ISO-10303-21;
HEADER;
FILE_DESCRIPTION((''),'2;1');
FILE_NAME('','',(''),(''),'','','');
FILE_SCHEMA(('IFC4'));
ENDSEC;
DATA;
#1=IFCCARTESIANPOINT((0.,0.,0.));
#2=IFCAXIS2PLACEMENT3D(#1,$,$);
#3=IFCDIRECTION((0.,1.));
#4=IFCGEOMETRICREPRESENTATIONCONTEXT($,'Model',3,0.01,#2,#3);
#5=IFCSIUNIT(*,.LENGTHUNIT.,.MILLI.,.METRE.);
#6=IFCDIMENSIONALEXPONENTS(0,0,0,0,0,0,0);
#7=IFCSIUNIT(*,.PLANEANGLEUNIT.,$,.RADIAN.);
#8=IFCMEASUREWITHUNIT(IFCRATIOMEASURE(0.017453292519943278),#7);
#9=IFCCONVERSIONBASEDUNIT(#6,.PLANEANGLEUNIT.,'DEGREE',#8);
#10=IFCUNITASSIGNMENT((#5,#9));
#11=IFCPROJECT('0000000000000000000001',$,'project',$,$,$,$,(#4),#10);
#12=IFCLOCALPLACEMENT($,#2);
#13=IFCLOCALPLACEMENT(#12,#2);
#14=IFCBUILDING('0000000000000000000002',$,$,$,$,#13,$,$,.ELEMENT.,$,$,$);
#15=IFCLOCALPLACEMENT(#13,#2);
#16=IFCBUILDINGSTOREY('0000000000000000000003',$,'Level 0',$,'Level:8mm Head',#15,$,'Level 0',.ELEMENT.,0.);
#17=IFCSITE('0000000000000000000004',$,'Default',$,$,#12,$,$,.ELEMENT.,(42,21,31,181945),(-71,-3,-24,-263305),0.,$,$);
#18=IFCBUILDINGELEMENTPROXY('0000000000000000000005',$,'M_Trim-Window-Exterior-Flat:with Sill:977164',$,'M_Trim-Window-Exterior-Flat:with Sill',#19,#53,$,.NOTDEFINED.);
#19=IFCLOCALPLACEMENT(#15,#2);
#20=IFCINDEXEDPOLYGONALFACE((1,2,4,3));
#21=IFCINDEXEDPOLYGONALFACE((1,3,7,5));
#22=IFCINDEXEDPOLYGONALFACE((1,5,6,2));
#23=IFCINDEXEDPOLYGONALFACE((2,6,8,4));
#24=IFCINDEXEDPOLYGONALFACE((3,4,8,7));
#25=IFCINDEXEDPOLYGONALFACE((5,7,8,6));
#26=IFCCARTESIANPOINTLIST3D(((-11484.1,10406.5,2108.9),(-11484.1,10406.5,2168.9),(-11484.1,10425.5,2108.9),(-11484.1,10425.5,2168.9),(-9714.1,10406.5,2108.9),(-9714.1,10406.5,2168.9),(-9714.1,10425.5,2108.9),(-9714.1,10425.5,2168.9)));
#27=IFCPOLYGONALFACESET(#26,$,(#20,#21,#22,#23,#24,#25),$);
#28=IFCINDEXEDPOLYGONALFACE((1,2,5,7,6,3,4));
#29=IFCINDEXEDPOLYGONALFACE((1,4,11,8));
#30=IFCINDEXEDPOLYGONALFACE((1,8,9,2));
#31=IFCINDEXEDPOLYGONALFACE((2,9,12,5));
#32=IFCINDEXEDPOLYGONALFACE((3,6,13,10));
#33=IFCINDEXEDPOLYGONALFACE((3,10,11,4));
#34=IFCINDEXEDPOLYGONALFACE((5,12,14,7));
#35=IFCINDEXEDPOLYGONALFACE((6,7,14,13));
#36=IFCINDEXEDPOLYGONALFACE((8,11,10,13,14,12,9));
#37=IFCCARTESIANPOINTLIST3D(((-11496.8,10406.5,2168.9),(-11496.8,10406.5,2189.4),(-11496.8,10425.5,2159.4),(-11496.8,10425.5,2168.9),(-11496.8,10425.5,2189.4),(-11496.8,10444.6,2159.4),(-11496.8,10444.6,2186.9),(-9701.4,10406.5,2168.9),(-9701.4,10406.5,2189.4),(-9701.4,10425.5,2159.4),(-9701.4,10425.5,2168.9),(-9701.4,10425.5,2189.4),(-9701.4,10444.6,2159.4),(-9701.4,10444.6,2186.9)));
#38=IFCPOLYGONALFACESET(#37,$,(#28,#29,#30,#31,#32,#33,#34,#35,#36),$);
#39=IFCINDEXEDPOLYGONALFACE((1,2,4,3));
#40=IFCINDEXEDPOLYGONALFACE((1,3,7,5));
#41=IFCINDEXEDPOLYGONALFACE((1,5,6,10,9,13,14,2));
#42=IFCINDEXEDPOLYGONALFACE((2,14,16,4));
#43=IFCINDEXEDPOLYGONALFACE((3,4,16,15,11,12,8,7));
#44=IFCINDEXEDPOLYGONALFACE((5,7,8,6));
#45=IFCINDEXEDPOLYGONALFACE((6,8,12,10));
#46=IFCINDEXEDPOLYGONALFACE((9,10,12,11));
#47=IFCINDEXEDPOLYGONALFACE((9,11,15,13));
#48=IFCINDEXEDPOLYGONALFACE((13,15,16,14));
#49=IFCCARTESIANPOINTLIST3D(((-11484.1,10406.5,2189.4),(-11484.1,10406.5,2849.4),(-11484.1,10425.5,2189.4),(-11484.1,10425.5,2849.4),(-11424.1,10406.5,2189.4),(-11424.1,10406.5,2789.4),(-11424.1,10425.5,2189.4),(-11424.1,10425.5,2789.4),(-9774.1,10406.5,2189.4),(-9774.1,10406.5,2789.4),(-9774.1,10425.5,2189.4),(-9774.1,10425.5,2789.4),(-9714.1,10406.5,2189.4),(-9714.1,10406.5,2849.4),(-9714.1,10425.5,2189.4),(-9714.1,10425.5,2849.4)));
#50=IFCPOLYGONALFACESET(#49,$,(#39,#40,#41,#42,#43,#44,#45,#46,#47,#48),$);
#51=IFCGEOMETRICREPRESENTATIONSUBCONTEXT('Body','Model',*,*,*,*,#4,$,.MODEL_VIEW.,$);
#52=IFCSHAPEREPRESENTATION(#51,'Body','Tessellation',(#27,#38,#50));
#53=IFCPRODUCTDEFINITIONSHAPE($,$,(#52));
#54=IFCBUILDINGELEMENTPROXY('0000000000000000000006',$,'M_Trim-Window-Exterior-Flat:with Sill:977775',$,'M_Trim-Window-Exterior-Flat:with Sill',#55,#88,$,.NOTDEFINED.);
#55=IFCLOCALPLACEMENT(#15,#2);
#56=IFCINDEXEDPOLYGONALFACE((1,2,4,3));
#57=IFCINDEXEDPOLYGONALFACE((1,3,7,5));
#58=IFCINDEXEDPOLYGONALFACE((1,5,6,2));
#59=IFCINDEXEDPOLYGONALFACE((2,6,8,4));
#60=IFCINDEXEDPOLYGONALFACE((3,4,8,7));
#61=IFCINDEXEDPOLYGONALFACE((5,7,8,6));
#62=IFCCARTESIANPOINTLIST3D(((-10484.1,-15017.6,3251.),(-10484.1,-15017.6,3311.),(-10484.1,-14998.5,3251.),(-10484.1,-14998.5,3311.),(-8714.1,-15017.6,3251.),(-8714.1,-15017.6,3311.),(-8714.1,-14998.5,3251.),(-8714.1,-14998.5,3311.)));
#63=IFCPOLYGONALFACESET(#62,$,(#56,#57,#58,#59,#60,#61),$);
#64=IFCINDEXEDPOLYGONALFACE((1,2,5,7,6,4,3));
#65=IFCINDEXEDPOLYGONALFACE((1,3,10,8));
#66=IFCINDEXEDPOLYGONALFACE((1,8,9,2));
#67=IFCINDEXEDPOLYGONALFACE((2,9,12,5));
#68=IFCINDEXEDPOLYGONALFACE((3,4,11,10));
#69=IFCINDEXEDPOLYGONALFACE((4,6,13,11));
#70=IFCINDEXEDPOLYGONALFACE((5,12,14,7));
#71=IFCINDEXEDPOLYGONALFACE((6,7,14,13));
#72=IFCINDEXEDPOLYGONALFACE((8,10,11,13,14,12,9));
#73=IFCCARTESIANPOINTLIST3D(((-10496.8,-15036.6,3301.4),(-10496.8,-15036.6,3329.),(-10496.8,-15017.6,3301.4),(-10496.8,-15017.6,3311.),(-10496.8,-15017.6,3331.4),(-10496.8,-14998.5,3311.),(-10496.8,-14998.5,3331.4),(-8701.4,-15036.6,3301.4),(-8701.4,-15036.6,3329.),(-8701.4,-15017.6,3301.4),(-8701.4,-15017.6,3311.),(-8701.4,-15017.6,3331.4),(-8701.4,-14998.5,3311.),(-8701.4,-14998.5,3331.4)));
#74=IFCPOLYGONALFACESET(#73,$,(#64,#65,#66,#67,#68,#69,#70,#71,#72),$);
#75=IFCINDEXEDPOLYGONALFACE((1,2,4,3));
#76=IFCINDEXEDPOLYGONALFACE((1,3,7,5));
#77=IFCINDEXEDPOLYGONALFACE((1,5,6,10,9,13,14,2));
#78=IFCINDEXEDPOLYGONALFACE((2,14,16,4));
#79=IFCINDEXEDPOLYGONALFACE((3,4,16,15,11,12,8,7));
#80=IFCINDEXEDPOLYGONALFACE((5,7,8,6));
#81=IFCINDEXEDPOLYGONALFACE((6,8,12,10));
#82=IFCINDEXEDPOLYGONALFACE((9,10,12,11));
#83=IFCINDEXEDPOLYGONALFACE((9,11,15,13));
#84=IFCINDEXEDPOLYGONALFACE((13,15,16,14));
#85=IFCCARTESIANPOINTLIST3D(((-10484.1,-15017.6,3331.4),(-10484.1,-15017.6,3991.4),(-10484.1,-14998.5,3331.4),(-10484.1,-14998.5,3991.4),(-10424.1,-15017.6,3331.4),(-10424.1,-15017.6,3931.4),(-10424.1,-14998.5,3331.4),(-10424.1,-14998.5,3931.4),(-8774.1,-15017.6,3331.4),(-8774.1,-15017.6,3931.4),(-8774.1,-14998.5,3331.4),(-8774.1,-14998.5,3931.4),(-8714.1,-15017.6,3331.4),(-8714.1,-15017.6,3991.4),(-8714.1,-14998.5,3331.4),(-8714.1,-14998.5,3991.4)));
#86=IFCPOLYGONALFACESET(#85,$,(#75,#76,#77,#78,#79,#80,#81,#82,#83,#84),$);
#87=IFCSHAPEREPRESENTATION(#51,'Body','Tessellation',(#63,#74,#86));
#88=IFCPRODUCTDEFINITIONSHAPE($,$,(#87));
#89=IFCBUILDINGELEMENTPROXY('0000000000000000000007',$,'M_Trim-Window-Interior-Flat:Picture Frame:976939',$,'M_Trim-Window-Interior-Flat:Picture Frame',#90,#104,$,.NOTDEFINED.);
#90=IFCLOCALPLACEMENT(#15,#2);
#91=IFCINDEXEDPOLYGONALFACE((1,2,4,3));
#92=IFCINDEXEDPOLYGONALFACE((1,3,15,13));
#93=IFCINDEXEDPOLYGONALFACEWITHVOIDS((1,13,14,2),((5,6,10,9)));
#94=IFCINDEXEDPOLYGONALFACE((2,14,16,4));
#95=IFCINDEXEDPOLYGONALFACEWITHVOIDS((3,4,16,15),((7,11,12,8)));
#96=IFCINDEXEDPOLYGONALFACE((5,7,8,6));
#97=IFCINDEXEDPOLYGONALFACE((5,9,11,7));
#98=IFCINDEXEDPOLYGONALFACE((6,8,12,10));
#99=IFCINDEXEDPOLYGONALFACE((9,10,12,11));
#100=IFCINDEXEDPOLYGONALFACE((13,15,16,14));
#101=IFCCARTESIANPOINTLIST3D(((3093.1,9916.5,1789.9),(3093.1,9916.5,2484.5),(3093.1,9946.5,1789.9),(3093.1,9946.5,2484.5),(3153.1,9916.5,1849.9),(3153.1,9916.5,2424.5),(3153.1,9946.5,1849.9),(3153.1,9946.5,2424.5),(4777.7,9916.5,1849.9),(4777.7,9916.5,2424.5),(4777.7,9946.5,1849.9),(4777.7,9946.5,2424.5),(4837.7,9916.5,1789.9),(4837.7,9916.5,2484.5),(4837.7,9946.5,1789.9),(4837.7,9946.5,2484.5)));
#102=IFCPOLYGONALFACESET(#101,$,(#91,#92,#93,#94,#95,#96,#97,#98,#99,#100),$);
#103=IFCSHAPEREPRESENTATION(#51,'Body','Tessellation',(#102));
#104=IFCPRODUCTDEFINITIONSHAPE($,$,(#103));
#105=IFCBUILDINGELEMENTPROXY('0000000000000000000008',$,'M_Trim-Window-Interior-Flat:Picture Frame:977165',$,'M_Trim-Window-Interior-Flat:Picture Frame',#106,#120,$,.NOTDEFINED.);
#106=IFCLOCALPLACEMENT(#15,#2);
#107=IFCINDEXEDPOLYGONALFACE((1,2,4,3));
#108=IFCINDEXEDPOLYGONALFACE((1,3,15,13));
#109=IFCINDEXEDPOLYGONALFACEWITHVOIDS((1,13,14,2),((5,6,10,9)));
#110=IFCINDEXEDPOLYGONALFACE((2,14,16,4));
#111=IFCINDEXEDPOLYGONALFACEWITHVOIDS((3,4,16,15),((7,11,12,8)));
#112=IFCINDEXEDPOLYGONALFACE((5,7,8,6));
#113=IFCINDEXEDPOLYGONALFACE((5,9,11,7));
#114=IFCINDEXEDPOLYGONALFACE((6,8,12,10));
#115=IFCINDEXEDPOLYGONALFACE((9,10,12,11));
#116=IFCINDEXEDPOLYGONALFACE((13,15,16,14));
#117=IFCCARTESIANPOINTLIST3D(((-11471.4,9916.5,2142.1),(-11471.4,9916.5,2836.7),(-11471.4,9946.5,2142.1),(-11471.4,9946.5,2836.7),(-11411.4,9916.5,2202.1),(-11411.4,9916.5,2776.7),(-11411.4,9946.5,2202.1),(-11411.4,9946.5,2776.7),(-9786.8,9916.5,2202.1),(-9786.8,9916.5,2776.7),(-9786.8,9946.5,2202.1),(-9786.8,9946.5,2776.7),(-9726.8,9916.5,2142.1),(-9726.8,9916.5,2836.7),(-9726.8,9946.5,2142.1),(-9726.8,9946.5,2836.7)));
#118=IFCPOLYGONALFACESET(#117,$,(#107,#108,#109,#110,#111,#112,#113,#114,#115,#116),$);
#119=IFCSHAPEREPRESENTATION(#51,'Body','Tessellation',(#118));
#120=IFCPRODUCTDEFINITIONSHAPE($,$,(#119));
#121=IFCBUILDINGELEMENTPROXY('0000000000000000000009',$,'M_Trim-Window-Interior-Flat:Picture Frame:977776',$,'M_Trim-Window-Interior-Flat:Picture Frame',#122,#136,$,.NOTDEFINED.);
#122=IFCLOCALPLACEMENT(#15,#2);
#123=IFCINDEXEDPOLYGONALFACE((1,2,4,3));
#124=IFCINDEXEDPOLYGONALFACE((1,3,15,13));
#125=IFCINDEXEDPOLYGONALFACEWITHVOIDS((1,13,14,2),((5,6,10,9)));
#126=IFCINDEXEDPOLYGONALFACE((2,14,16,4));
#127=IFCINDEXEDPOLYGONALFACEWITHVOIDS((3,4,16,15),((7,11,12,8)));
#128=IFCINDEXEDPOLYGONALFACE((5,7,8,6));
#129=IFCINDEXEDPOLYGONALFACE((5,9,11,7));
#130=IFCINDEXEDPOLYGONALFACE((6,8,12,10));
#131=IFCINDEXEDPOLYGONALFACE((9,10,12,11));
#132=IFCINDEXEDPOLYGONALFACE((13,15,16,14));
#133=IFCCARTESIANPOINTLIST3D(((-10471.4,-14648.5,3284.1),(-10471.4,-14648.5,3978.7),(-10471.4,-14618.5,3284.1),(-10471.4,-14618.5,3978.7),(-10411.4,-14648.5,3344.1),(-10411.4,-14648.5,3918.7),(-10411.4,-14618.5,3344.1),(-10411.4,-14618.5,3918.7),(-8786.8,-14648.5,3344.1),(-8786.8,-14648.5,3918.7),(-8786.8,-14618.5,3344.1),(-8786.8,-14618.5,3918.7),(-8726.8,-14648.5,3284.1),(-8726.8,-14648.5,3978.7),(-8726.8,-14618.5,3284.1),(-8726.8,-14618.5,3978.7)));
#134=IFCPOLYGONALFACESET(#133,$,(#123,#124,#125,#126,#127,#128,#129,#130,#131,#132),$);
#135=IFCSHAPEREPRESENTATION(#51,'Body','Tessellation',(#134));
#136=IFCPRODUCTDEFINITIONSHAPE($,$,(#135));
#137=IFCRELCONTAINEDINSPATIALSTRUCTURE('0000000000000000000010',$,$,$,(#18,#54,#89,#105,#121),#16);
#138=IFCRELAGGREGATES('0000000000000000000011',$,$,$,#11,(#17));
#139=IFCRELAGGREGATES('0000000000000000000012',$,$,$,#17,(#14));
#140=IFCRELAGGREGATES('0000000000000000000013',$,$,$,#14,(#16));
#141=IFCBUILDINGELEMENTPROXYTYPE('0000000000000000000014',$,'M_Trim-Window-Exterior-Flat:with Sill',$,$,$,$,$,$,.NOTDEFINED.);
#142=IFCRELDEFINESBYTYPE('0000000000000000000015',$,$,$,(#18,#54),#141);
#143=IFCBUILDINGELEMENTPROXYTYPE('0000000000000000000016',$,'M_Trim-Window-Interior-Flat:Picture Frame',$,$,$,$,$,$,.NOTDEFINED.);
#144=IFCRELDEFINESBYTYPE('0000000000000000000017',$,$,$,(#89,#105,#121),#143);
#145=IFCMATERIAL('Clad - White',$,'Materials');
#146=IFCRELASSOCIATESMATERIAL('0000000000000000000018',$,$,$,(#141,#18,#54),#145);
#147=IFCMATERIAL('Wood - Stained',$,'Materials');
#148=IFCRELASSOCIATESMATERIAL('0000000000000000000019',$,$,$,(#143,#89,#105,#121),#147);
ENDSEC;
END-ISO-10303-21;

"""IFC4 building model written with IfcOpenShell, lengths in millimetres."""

from ifc_helpers import new_model, entity, si_unit, converted_unit, direction, frame, origin, place, context, subcontext, project, spatial, indexed_curve, outline, extrude, source, transform, mapped, material, type_object, type_shapes, element, save


model = new_model("IFC4")

# Units and contexts
model_context = context("Model", 3, precision=0.01, world=origin(), true_north=direction((0.0, 1.0)))
body_context = subcontext(model_context, "Body", "Model", "MODEL_VIEW")
ifc_project = project(units=[si_unit("LENGTHUNIT", "METRE", prefix="MILLI"), converted_unit("PLANEANGLEUNIT", "DEGREE", entity("IfcRatioMeasure", 0.017453292519943278), si_unit("PLANEANGLEUNIT", "RADIAN"), dimensions=[0, 0, 0, 0, 0, 0, 0])], contexts=[model_context])

# Site, building, storey
site_placement = place(None, origin())
site = spatial("IfcSite", under=ifc_project, at=site_placement, Name="Default", CompositionType="ELEMENT", RefLatitude=(42, 21, 31, 181945), RefLongitude=(-71, -3, -24, -263305), RefElevation=0.0)
building_placement = place(site_placement, origin())
building = spatial("IfcBuilding", under=site, at=building_placement, CompositionType="ELEMENT")
storey_placement = place(building_placement, origin())
storey = spatial("IfcBuildingStorey", under=building, at=storey_placement, Name="Level 0", ObjectType="Level:8mm Head", LongName="Level 0", CompositionType="ELEMENT", Elevation=0.0)

# Building element proxies
ifc_material_1 = material(Name="Clad - White", Category="Materials")
ifc_material_2 = material(Name="Wood - Stained", Category="Materials")
building_element_proxy_type_1 = type_object("IfcBuildingElementProxyType", Name="M_Trim-Window-Exterior-Flat:with Sill", PredefinedType="NOTDEFINED", material=ifc_material_1)
shared_shape_1 = source(origin(), body_context, "Body", "SweptSolid", [
    extrude(outline(indexed_curve([(-885.0, -30.0), (885.0, -30.0), (885.0, 30.0), (-885.0, 30.0), (-885.0, -30.0)], self_intersect=False)), frame((0.0, -650.4, 0.0), z_axis=(0.0, 0.0, 1.0), x_axis=(-1.0, 0.0, 0.0)), (0.0, 0.0, 1.0), 19.0),
    extrude(outline(indexed_curve([(-19.0, -15.2), (0.0, -15.2), (0.0, -5.7), (19.0, -5.7), (19.0, 14.8), (0.0, 14.8), (-19.0, 12.3), (-19.0, -15.2)], self_intersect=False)), frame((-897.7, -614.8, 19.0), z_axis=(1.0, 0.0, 0.0), x_axis=(0.0, 0.0, -1.0)), (0.0, 0.0, 1.0), 1795.4),
    extrude(outline(indexed_curve([(-345.0, -885.0), (315.0, -885.0), (315.0, -825.0), (-285.0, -825.0), (-285.0, 825.0), (315.0, 825.0), (315.0, 885.0), (-345.0, 885.0), (-345.0, -885.0)], self_intersect=False)), frame((0.0, -285.0, 0.0), z_axis=(0.0, 0.0, 1.0), x_axis=(0.0, -1.0, 0.0)), (0.0, 0.0, 1.0), 19.0),
])
type_shapes(building_element_proxy_type_1, [shared_shape_1])
for number, where, z_axis, x_axis, name in (
    (1, (-10599.1, 10406.5, 2789.4), (0.0, 1.0, 0.0), (-1.0, 0.0, 0.0), "M_Trim-Window-Exterior-Flat:with Sill:977164"),
    (2, (-9599.1, -14998.5, 3931.4), (0.0, -1.0, 0.0), (1.0, 0.0, 0.0), "M_Trim-Window-Exterior-Flat:with Sill:977775"),
):
    element("IfcBuildingElementProxy", number, at=place(storey_placement, frame(where, z_axis=z_axis, x_axis=x_axis)), inside=storey, type_object=building_element_proxy_type_1, material=ifc_material_1, Name=name, ObjectType="M_Trim-Window-Exterior-Flat:with Sill", PredefinedType="NOTDEFINED", context=body_context, shape_type="MappedRepresentation", body=[
        mapped(shared_shape_1, transform((0.0, 0.0, 0.0), scale=1.0)),
    ])
building_element_proxy_type_2 = type_object("IfcBuildingElementProxyType", Name="M_Trim-Window-Interior-Flat:Picture Frame", PredefinedType="NOTDEFINED", material=ifc_material_2)
shared_shape_2 = source(origin(), body_context, "Body", "SweptSolid", [
    extrude(outline(indexed_curve([(-872.3, -347.3), (872.3, -347.3), (872.3, 347.3), (-872.3, 347.3), (-872.3, -347.3)], self_intersect=False), holes=[indexed_curve([(-812.3, -287.3), (-812.3, 287.3), (812.3, 287.3), (812.3, -287.3), (-812.3, -287.3)], self_intersect=False)]), frame((0.0, -300.0, 0.0), z_axis=(0.0, 0.0, 1.0), x_axis=(-1.0, 0.0, 0.0)), (0.0, 0.0, 1.0), 30.0),
])
type_shapes(building_element_proxy_type_2, [shared_shape_2])
for number, where, z_axis, x_axis, name in (
    (3, (3965.4, 9946.5, 2437.2), (0.0, -1.0, 0.0), (1.0, 0.0, 0.0), "M_Trim-Window-Interior-Flat:Picture Frame:976939"),
    (4, (-10599.1, 9946.5, 2789.4), (0.0, -1.0, 0.0), (1.0, 0.0, 0.0), "M_Trim-Window-Interior-Flat:Picture Frame:977165"),
    (5, (-9599.1, -14648.5, 3931.4), (0.0, 1.0, 0.0), (-1.0, 0.0, 0.0), "M_Trim-Window-Interior-Flat:Picture Frame:977776"),
):
    element("IfcBuildingElementProxy", number, at=place(storey_placement, frame(where, z_axis=z_axis, x_axis=x_axis)), inside=storey, type_object=building_element_proxy_type_2, material=ifc_material_2, Name=name, ObjectType="M_Trim-Window-Interior-Flat:Picture Frame", PredefinedType="NOTDEFINED", context=body_context, shape_type="MappedRepresentation", body=[
        mapped(shared_shape_2, transform((0.0, 0.0, 0.0), scale=1.0)),
    ])

save(model, "model.ifc")
